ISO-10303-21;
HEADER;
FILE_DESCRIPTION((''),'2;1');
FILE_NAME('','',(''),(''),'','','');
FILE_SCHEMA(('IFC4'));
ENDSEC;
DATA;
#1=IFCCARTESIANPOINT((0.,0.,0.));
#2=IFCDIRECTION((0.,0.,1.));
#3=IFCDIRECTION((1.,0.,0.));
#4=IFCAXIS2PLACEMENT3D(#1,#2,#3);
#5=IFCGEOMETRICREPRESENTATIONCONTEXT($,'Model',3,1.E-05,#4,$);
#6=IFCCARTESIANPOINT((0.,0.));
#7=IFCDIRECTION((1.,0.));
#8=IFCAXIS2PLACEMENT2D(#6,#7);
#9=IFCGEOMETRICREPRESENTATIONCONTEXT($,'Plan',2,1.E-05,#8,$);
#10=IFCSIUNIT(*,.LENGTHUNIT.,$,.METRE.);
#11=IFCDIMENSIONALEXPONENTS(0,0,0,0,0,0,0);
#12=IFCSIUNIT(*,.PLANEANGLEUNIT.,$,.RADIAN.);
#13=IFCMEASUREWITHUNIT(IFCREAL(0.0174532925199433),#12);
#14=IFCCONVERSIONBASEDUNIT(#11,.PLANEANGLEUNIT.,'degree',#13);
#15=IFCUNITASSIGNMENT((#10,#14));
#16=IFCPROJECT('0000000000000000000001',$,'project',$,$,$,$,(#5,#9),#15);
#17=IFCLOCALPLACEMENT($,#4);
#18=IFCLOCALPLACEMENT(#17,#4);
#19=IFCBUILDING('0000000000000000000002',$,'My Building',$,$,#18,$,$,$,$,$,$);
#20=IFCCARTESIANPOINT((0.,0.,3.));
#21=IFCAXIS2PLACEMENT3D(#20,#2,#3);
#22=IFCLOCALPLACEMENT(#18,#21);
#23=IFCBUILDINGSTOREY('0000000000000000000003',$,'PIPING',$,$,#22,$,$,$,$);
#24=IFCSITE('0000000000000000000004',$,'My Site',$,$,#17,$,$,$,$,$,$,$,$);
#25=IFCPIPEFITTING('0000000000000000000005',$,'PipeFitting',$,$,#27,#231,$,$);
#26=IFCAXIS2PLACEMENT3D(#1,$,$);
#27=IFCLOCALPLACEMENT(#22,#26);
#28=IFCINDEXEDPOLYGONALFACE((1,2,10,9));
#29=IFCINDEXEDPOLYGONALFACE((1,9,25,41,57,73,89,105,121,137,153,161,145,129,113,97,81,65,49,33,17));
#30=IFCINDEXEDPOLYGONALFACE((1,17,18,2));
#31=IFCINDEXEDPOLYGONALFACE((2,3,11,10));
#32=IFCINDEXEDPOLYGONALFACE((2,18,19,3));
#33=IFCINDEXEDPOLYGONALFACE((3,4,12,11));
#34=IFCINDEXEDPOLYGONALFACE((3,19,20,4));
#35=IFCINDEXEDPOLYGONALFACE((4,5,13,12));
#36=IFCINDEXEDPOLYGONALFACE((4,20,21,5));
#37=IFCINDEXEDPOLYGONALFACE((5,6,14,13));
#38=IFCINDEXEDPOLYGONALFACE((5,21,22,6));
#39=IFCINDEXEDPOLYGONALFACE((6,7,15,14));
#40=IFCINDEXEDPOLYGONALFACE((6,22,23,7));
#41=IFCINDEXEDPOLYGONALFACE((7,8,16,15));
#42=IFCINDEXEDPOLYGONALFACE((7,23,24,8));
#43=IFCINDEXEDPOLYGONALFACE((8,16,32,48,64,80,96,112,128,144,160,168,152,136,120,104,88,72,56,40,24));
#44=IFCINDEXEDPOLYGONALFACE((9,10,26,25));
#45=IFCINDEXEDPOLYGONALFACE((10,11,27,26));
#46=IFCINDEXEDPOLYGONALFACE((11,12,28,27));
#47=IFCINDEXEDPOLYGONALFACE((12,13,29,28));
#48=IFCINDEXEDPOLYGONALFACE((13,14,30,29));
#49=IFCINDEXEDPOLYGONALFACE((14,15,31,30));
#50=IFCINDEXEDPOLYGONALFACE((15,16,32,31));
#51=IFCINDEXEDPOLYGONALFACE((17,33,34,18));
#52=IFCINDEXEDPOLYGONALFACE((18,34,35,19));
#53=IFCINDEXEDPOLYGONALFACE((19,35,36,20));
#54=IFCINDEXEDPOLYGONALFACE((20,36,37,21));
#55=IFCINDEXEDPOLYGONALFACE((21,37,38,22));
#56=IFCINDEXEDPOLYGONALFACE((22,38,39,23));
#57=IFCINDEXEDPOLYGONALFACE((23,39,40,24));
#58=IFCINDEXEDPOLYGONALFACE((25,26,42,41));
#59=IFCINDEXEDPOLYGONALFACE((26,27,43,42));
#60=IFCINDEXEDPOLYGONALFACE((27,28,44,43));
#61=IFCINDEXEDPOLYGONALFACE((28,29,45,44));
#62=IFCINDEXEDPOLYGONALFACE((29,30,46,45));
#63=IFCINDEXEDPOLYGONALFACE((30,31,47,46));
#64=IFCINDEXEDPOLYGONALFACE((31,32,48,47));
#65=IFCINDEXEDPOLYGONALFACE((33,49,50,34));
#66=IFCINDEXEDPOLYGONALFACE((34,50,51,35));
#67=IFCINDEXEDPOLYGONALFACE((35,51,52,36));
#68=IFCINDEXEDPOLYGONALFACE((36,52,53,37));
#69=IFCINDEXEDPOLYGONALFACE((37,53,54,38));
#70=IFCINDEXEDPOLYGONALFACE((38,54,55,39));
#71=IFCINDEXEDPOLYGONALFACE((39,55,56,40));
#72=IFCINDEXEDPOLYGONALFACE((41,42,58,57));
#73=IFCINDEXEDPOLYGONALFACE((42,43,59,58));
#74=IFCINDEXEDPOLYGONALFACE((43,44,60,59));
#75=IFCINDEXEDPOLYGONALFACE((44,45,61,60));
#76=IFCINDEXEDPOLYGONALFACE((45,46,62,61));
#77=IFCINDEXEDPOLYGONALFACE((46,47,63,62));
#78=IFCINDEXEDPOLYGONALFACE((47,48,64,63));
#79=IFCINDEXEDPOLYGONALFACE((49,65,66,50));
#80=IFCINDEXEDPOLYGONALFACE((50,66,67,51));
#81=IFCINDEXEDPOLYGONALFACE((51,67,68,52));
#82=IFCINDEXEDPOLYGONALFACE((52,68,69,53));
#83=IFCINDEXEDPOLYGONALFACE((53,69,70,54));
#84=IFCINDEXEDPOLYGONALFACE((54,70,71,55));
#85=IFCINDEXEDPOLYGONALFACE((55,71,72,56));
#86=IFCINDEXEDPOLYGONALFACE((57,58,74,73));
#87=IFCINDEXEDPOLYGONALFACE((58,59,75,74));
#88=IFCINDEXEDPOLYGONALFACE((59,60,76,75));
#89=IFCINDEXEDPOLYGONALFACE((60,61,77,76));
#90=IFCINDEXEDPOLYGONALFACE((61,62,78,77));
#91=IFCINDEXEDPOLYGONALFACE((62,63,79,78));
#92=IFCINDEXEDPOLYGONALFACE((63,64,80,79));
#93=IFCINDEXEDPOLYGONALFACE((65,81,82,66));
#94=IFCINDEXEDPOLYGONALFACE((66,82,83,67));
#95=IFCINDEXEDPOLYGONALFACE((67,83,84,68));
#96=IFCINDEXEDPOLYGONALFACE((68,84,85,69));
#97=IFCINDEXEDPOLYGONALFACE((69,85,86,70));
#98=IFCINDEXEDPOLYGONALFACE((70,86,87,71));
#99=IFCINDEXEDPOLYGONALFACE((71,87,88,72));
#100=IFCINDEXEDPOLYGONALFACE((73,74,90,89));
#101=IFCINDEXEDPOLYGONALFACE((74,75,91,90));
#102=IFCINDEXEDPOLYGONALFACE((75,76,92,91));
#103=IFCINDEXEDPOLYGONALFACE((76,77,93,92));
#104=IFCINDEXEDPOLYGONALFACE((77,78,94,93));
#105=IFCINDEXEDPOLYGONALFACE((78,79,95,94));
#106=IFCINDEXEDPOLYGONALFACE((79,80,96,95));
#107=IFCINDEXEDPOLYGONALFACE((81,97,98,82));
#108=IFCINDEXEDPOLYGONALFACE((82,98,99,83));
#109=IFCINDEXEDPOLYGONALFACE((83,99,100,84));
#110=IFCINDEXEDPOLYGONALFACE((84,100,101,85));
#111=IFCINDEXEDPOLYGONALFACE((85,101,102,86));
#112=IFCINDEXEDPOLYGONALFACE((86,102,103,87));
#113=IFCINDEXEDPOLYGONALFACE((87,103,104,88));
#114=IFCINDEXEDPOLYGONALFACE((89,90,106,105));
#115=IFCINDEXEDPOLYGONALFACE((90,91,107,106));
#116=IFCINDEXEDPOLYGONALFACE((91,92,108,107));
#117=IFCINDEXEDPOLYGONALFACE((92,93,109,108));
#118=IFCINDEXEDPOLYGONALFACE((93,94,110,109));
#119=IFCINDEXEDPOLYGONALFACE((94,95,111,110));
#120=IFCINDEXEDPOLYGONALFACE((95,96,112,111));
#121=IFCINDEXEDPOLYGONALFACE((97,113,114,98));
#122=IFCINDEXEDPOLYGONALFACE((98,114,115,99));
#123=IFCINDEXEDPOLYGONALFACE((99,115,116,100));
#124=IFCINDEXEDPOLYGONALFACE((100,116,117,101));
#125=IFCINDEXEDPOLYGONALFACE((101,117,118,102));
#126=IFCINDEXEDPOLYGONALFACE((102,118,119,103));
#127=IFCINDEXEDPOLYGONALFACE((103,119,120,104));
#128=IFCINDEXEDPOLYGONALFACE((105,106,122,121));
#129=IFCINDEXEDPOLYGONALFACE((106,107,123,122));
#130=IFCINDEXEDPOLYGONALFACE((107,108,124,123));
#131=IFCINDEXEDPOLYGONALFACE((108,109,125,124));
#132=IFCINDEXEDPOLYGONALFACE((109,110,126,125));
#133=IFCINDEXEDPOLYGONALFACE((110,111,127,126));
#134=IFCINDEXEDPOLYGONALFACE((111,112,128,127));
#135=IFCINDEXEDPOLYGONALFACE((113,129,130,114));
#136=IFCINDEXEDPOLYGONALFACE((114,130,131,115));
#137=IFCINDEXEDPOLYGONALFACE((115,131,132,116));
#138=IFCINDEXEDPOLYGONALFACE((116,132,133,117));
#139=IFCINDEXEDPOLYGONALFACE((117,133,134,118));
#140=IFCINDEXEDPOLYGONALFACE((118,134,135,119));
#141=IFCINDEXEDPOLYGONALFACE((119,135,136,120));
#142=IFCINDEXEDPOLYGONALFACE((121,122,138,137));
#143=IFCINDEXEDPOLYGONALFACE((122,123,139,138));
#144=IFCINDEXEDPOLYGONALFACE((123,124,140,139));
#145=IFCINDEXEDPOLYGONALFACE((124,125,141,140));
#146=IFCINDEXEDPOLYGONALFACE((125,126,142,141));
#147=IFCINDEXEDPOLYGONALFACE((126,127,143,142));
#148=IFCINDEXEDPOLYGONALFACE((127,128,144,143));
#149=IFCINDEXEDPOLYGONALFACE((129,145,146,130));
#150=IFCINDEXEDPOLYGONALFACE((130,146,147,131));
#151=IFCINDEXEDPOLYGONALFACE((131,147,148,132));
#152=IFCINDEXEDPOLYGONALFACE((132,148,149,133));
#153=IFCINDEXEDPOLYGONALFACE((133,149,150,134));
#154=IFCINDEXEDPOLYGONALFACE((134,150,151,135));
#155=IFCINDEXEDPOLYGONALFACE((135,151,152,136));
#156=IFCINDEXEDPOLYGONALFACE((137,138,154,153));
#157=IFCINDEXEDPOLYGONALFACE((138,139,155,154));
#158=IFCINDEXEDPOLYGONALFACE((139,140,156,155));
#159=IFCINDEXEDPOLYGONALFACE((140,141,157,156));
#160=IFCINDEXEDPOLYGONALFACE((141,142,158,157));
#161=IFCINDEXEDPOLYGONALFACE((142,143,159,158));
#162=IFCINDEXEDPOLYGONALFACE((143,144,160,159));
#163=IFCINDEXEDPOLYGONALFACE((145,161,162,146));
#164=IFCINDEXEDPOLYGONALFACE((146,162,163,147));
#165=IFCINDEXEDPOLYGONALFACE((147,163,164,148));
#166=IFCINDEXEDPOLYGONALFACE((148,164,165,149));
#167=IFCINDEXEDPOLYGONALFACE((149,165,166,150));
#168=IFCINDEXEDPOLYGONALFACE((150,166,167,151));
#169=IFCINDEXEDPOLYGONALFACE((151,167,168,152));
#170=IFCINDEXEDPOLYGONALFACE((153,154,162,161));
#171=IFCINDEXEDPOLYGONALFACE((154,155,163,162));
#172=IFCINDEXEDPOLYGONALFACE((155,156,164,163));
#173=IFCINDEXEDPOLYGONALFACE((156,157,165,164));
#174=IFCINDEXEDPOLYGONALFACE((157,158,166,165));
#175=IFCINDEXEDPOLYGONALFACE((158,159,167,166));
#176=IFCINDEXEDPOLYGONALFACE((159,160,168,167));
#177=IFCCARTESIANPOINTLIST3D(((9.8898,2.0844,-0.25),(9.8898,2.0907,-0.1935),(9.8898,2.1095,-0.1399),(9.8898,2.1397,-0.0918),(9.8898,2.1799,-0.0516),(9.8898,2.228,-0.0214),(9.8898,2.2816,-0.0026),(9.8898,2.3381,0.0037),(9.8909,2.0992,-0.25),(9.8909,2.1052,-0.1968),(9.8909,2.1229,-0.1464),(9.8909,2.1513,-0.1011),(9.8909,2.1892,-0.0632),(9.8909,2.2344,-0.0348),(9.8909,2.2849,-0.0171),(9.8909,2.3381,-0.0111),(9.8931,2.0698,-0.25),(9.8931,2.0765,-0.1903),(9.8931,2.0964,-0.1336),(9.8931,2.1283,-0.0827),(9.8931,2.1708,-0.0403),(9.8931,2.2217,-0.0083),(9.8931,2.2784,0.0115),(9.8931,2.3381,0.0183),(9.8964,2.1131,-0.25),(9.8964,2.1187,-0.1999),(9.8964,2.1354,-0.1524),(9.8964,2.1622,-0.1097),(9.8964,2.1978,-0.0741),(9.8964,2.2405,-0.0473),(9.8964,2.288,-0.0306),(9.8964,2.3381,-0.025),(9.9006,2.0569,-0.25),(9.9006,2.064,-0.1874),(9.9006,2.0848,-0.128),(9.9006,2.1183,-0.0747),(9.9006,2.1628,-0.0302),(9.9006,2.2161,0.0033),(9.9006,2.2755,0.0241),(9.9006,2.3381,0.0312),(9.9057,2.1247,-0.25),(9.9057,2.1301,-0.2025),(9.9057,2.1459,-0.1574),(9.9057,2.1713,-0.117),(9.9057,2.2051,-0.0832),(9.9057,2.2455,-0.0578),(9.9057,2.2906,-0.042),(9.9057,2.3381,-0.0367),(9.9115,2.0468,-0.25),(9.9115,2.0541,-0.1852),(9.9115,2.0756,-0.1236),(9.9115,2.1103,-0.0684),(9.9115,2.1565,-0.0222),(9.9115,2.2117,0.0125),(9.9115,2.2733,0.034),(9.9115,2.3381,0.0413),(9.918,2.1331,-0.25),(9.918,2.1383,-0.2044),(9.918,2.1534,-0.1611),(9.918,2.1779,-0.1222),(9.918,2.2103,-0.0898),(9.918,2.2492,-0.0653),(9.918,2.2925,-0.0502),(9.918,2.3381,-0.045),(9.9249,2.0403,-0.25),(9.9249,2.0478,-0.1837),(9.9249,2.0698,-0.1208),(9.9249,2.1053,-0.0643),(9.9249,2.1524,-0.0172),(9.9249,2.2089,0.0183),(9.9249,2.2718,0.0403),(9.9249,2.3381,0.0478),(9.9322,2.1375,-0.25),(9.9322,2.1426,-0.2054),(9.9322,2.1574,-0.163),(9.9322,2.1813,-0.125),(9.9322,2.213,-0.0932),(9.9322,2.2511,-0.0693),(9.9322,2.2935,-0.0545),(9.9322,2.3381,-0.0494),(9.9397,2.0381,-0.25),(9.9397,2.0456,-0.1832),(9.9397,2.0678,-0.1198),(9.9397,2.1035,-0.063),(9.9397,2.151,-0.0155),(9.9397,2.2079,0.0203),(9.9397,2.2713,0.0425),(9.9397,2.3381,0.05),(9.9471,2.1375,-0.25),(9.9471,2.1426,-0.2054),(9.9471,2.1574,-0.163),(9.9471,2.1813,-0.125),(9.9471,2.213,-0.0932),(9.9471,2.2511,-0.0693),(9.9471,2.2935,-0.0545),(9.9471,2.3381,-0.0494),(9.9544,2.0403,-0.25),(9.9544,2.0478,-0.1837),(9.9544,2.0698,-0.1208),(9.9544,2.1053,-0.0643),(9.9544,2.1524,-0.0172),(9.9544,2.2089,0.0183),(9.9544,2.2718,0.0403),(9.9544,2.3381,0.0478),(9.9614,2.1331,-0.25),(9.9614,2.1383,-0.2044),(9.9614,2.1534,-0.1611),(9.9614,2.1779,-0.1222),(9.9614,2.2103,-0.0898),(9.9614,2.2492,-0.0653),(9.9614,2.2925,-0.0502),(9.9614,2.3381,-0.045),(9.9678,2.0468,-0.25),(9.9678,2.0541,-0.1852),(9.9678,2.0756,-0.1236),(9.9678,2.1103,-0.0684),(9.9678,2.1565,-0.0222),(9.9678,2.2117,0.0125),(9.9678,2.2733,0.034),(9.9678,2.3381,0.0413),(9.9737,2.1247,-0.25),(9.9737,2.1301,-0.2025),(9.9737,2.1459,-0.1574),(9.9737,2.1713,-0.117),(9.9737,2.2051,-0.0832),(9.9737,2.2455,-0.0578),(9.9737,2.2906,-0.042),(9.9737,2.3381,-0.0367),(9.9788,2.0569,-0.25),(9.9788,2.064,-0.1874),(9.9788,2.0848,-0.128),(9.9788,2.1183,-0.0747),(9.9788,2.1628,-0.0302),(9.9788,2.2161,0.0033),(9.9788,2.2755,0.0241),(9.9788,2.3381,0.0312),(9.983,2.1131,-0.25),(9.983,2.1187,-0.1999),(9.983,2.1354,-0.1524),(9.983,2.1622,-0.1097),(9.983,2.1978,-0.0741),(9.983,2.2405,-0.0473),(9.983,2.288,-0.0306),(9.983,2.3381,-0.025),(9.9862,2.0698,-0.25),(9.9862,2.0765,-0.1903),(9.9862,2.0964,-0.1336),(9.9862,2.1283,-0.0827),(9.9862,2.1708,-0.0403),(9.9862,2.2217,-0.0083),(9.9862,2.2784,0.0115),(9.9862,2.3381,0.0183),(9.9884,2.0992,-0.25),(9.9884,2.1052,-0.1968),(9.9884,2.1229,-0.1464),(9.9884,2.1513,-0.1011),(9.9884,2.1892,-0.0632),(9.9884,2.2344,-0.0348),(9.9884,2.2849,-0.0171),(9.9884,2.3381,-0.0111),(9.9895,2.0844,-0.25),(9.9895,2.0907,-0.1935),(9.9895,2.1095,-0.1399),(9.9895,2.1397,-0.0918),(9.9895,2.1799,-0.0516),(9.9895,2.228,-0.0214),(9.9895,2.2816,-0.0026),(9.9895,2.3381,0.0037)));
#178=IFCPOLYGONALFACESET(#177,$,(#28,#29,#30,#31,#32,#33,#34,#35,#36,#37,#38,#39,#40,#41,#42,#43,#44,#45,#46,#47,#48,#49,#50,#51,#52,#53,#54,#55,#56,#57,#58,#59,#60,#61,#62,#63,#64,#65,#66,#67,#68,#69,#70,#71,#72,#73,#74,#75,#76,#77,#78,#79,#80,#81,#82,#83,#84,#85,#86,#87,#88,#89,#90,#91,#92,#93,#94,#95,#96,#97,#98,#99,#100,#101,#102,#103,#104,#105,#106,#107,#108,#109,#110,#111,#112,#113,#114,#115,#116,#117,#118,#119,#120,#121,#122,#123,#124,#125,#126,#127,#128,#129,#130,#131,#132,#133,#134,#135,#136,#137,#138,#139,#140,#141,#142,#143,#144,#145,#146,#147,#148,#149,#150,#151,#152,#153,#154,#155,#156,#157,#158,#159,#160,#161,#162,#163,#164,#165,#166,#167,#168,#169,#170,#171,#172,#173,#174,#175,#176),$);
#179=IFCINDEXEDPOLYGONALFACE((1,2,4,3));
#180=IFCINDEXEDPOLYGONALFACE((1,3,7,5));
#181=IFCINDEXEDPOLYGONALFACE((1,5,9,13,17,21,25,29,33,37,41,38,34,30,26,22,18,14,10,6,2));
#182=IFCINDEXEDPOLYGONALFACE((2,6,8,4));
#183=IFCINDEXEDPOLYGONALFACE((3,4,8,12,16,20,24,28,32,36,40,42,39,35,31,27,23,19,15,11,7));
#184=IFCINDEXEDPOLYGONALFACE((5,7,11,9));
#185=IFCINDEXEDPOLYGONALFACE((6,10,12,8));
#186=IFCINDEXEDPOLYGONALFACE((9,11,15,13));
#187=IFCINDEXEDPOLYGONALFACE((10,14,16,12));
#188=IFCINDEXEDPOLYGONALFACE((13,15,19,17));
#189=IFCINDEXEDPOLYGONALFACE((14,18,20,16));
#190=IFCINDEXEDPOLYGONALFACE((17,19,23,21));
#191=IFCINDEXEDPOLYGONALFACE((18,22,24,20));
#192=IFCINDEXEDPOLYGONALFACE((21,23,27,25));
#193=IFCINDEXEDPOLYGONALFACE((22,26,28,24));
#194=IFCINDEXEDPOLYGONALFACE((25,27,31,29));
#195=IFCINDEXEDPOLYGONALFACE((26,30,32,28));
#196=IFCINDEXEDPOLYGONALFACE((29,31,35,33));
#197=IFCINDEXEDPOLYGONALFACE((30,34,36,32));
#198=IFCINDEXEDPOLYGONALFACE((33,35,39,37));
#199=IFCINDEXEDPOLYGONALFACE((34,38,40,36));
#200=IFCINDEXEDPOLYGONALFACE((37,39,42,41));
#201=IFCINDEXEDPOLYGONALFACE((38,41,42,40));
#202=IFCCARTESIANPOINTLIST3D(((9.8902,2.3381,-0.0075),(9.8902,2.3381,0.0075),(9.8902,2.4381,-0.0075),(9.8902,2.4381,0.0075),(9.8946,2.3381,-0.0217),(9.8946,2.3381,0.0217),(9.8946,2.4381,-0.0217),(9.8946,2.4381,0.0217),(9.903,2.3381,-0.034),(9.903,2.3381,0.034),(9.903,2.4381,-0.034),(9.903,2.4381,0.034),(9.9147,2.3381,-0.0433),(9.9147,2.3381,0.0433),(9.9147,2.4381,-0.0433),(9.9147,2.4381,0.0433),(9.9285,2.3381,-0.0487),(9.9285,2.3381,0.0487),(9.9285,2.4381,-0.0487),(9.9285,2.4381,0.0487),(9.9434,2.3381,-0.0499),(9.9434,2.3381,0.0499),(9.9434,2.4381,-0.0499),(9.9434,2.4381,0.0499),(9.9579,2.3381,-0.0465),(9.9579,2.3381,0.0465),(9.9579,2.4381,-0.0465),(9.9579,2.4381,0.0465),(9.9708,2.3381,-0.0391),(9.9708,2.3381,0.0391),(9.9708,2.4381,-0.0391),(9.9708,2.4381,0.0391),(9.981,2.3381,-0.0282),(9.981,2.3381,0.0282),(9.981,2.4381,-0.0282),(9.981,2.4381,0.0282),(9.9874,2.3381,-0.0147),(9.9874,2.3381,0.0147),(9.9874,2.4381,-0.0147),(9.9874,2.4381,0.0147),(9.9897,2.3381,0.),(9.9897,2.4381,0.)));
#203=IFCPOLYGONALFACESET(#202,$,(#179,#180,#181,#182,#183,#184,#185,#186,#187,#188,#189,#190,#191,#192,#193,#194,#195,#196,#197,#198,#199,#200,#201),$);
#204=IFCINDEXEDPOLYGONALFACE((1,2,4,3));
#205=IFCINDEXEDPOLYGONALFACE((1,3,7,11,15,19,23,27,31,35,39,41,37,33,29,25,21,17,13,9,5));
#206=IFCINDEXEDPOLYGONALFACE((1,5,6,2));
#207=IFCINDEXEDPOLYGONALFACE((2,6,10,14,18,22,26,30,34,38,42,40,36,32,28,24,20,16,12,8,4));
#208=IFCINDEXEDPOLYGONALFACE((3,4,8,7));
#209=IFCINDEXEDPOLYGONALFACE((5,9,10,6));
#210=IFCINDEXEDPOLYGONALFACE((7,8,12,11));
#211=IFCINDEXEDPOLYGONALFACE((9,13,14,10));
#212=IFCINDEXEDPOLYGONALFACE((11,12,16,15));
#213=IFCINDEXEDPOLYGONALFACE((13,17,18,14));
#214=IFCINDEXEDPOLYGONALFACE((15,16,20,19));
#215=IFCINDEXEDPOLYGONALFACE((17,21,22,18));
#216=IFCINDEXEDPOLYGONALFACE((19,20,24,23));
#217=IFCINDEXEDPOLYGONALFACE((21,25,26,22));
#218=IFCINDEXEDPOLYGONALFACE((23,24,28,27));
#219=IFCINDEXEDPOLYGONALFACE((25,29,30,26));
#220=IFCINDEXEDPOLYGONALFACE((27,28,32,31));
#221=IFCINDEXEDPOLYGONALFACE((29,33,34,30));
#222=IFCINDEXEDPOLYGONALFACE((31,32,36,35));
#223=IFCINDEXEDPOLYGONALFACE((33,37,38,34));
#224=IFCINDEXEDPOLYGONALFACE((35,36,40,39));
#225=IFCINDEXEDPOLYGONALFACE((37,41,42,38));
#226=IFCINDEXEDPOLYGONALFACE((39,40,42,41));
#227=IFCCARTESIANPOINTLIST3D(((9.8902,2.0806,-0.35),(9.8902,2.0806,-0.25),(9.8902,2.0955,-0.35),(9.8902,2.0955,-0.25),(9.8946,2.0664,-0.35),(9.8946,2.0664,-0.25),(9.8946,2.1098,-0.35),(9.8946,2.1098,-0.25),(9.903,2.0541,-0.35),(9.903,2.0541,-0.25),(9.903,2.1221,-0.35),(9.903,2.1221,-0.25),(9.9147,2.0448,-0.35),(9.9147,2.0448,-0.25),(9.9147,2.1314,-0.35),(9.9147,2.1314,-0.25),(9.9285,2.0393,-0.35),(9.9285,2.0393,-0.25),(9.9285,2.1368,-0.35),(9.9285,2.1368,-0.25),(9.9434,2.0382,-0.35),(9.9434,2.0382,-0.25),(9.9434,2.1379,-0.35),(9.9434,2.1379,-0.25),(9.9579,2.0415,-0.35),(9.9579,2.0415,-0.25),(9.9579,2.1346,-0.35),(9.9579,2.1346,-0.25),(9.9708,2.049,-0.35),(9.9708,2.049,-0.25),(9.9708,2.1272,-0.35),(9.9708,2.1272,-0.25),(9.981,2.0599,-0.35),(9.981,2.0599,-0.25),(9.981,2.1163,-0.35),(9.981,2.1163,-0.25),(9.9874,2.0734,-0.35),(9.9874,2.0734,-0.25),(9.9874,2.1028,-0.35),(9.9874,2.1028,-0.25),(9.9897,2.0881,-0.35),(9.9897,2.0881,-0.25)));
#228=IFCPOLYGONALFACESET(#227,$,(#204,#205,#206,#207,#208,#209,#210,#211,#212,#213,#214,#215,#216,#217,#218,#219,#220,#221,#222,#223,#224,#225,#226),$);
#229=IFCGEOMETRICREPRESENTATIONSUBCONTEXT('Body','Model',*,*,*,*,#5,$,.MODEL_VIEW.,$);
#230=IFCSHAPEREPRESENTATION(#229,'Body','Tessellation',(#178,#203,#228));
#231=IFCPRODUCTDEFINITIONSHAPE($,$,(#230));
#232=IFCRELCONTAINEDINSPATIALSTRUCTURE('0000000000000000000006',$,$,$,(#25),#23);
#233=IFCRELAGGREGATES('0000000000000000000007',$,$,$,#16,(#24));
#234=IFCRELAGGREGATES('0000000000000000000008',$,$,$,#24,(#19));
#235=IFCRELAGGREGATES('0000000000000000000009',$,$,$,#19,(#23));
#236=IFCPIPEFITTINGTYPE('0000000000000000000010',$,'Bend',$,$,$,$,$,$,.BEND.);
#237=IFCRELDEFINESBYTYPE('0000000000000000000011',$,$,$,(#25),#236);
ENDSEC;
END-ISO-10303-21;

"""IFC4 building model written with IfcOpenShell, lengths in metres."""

from ifc_helpers import new_model, entity, si_unit, converted_unit, frame, origin_with_axes, origin_2d_with_axis, place, context, subcontext, project, spatial, circle, extrude, source, transform, mapped, type_object, type_shapes, element, save


model = new_model("IFC4")

# Units and contexts
model_context = context("Model", 3, precision=1e-05, world=origin_with_axes())
plan_context = context("Plan", 2, precision=1e-05, world=origin_2d_with_axis())
body_context = subcontext(model_context, "Body", "Model", "MODEL_VIEW")
ifc_project = project(units=[si_unit("LENGTHUNIT", "METRE"), converted_unit("PLANEANGLEUNIT", "degree", entity("IfcReal", 0.0174532925199433), si_unit("PLANEANGLEUNIT", "RADIAN"), dimensions=[0, 0, 0, 0, 0, 0, 0])], contexts=[model_context, plan_context])

# Site, building, storey
site_placement = place(None, origin_with_axes())
site = spatial("IfcSite", under=ifc_project, at=site_placement, Name="My Site")
building_placement = place(site_placement, origin_with_axes())
building = spatial("IfcBuilding", under=site, at=building_placement, Name="My Building")
storey_placement = place(building_placement, frame((0.0, 0.0, 3.0), z_axis=(0.0, 0.0, 1.0), x_axis=(1.0, 0.0, 0.0)))
storey = spatial("IfcBuildingStorey", under=building, at=storey_placement, Name="PIPING")

# Pipe fitting
pipe_fitting_type = type_object("IfcPipeFittingType", Name="Bend", PredefinedType="BEND")
shared_shape = source(origin_with_axes(), body_context, "Body", "SolidModel", [
    entity("IfcSweptDiskSolid", entity("IfcIndexedPolyCurve", entity("IfcCartesianPointList3D", [[0.0, 0.0, 0.1], [0.0, -0.0732, 0.2768], [0.0, -0.25, 0.35]]), [entity("IfcArcIndex", [1, 2, 3])]), 0.05),
    extrude(circle(Radius=0.05), origin_with_axes(), (0.0, 0.0, 1.0), 0.1),
    extrude(circle(Radius=0.05), frame((0.0, -0.25, 0.35), z_axis=(0.0, -1.0, 0.0), x_axis=(1.0, 0.0, 0.0)), (0.0, 0.0, 1.0), 0.1),
])
type_shapes(pipe_fitting_type, [shared_shape])
for number, where, z_axis, x_axis, name in (
    (1, (9.9397, 2.4381, 0.0), (0.0, -1.0, 0.0), (1.0, 0.0, 0.0), "PipeFitting"),
):
    element("IfcPipeFitting", number, at=place(storey_placement, frame(where, z_axis=z_axis, x_axis=x_axis)), inside=storey, type_object=pipe_fitting_type, Name=name, context=body_context, shape_type="MappedRepresentation", body=[
        mapped(shared_shape, transform((0.0, 0.0, 0.0), x_axis=(1.0, 0.0, 0.0), y_axis=(0.0, 1.0, 0.0), z_axis=(0.0, 0.0, 1.0), scale=1.0)),
    ])

save(model, "model.ifc")
